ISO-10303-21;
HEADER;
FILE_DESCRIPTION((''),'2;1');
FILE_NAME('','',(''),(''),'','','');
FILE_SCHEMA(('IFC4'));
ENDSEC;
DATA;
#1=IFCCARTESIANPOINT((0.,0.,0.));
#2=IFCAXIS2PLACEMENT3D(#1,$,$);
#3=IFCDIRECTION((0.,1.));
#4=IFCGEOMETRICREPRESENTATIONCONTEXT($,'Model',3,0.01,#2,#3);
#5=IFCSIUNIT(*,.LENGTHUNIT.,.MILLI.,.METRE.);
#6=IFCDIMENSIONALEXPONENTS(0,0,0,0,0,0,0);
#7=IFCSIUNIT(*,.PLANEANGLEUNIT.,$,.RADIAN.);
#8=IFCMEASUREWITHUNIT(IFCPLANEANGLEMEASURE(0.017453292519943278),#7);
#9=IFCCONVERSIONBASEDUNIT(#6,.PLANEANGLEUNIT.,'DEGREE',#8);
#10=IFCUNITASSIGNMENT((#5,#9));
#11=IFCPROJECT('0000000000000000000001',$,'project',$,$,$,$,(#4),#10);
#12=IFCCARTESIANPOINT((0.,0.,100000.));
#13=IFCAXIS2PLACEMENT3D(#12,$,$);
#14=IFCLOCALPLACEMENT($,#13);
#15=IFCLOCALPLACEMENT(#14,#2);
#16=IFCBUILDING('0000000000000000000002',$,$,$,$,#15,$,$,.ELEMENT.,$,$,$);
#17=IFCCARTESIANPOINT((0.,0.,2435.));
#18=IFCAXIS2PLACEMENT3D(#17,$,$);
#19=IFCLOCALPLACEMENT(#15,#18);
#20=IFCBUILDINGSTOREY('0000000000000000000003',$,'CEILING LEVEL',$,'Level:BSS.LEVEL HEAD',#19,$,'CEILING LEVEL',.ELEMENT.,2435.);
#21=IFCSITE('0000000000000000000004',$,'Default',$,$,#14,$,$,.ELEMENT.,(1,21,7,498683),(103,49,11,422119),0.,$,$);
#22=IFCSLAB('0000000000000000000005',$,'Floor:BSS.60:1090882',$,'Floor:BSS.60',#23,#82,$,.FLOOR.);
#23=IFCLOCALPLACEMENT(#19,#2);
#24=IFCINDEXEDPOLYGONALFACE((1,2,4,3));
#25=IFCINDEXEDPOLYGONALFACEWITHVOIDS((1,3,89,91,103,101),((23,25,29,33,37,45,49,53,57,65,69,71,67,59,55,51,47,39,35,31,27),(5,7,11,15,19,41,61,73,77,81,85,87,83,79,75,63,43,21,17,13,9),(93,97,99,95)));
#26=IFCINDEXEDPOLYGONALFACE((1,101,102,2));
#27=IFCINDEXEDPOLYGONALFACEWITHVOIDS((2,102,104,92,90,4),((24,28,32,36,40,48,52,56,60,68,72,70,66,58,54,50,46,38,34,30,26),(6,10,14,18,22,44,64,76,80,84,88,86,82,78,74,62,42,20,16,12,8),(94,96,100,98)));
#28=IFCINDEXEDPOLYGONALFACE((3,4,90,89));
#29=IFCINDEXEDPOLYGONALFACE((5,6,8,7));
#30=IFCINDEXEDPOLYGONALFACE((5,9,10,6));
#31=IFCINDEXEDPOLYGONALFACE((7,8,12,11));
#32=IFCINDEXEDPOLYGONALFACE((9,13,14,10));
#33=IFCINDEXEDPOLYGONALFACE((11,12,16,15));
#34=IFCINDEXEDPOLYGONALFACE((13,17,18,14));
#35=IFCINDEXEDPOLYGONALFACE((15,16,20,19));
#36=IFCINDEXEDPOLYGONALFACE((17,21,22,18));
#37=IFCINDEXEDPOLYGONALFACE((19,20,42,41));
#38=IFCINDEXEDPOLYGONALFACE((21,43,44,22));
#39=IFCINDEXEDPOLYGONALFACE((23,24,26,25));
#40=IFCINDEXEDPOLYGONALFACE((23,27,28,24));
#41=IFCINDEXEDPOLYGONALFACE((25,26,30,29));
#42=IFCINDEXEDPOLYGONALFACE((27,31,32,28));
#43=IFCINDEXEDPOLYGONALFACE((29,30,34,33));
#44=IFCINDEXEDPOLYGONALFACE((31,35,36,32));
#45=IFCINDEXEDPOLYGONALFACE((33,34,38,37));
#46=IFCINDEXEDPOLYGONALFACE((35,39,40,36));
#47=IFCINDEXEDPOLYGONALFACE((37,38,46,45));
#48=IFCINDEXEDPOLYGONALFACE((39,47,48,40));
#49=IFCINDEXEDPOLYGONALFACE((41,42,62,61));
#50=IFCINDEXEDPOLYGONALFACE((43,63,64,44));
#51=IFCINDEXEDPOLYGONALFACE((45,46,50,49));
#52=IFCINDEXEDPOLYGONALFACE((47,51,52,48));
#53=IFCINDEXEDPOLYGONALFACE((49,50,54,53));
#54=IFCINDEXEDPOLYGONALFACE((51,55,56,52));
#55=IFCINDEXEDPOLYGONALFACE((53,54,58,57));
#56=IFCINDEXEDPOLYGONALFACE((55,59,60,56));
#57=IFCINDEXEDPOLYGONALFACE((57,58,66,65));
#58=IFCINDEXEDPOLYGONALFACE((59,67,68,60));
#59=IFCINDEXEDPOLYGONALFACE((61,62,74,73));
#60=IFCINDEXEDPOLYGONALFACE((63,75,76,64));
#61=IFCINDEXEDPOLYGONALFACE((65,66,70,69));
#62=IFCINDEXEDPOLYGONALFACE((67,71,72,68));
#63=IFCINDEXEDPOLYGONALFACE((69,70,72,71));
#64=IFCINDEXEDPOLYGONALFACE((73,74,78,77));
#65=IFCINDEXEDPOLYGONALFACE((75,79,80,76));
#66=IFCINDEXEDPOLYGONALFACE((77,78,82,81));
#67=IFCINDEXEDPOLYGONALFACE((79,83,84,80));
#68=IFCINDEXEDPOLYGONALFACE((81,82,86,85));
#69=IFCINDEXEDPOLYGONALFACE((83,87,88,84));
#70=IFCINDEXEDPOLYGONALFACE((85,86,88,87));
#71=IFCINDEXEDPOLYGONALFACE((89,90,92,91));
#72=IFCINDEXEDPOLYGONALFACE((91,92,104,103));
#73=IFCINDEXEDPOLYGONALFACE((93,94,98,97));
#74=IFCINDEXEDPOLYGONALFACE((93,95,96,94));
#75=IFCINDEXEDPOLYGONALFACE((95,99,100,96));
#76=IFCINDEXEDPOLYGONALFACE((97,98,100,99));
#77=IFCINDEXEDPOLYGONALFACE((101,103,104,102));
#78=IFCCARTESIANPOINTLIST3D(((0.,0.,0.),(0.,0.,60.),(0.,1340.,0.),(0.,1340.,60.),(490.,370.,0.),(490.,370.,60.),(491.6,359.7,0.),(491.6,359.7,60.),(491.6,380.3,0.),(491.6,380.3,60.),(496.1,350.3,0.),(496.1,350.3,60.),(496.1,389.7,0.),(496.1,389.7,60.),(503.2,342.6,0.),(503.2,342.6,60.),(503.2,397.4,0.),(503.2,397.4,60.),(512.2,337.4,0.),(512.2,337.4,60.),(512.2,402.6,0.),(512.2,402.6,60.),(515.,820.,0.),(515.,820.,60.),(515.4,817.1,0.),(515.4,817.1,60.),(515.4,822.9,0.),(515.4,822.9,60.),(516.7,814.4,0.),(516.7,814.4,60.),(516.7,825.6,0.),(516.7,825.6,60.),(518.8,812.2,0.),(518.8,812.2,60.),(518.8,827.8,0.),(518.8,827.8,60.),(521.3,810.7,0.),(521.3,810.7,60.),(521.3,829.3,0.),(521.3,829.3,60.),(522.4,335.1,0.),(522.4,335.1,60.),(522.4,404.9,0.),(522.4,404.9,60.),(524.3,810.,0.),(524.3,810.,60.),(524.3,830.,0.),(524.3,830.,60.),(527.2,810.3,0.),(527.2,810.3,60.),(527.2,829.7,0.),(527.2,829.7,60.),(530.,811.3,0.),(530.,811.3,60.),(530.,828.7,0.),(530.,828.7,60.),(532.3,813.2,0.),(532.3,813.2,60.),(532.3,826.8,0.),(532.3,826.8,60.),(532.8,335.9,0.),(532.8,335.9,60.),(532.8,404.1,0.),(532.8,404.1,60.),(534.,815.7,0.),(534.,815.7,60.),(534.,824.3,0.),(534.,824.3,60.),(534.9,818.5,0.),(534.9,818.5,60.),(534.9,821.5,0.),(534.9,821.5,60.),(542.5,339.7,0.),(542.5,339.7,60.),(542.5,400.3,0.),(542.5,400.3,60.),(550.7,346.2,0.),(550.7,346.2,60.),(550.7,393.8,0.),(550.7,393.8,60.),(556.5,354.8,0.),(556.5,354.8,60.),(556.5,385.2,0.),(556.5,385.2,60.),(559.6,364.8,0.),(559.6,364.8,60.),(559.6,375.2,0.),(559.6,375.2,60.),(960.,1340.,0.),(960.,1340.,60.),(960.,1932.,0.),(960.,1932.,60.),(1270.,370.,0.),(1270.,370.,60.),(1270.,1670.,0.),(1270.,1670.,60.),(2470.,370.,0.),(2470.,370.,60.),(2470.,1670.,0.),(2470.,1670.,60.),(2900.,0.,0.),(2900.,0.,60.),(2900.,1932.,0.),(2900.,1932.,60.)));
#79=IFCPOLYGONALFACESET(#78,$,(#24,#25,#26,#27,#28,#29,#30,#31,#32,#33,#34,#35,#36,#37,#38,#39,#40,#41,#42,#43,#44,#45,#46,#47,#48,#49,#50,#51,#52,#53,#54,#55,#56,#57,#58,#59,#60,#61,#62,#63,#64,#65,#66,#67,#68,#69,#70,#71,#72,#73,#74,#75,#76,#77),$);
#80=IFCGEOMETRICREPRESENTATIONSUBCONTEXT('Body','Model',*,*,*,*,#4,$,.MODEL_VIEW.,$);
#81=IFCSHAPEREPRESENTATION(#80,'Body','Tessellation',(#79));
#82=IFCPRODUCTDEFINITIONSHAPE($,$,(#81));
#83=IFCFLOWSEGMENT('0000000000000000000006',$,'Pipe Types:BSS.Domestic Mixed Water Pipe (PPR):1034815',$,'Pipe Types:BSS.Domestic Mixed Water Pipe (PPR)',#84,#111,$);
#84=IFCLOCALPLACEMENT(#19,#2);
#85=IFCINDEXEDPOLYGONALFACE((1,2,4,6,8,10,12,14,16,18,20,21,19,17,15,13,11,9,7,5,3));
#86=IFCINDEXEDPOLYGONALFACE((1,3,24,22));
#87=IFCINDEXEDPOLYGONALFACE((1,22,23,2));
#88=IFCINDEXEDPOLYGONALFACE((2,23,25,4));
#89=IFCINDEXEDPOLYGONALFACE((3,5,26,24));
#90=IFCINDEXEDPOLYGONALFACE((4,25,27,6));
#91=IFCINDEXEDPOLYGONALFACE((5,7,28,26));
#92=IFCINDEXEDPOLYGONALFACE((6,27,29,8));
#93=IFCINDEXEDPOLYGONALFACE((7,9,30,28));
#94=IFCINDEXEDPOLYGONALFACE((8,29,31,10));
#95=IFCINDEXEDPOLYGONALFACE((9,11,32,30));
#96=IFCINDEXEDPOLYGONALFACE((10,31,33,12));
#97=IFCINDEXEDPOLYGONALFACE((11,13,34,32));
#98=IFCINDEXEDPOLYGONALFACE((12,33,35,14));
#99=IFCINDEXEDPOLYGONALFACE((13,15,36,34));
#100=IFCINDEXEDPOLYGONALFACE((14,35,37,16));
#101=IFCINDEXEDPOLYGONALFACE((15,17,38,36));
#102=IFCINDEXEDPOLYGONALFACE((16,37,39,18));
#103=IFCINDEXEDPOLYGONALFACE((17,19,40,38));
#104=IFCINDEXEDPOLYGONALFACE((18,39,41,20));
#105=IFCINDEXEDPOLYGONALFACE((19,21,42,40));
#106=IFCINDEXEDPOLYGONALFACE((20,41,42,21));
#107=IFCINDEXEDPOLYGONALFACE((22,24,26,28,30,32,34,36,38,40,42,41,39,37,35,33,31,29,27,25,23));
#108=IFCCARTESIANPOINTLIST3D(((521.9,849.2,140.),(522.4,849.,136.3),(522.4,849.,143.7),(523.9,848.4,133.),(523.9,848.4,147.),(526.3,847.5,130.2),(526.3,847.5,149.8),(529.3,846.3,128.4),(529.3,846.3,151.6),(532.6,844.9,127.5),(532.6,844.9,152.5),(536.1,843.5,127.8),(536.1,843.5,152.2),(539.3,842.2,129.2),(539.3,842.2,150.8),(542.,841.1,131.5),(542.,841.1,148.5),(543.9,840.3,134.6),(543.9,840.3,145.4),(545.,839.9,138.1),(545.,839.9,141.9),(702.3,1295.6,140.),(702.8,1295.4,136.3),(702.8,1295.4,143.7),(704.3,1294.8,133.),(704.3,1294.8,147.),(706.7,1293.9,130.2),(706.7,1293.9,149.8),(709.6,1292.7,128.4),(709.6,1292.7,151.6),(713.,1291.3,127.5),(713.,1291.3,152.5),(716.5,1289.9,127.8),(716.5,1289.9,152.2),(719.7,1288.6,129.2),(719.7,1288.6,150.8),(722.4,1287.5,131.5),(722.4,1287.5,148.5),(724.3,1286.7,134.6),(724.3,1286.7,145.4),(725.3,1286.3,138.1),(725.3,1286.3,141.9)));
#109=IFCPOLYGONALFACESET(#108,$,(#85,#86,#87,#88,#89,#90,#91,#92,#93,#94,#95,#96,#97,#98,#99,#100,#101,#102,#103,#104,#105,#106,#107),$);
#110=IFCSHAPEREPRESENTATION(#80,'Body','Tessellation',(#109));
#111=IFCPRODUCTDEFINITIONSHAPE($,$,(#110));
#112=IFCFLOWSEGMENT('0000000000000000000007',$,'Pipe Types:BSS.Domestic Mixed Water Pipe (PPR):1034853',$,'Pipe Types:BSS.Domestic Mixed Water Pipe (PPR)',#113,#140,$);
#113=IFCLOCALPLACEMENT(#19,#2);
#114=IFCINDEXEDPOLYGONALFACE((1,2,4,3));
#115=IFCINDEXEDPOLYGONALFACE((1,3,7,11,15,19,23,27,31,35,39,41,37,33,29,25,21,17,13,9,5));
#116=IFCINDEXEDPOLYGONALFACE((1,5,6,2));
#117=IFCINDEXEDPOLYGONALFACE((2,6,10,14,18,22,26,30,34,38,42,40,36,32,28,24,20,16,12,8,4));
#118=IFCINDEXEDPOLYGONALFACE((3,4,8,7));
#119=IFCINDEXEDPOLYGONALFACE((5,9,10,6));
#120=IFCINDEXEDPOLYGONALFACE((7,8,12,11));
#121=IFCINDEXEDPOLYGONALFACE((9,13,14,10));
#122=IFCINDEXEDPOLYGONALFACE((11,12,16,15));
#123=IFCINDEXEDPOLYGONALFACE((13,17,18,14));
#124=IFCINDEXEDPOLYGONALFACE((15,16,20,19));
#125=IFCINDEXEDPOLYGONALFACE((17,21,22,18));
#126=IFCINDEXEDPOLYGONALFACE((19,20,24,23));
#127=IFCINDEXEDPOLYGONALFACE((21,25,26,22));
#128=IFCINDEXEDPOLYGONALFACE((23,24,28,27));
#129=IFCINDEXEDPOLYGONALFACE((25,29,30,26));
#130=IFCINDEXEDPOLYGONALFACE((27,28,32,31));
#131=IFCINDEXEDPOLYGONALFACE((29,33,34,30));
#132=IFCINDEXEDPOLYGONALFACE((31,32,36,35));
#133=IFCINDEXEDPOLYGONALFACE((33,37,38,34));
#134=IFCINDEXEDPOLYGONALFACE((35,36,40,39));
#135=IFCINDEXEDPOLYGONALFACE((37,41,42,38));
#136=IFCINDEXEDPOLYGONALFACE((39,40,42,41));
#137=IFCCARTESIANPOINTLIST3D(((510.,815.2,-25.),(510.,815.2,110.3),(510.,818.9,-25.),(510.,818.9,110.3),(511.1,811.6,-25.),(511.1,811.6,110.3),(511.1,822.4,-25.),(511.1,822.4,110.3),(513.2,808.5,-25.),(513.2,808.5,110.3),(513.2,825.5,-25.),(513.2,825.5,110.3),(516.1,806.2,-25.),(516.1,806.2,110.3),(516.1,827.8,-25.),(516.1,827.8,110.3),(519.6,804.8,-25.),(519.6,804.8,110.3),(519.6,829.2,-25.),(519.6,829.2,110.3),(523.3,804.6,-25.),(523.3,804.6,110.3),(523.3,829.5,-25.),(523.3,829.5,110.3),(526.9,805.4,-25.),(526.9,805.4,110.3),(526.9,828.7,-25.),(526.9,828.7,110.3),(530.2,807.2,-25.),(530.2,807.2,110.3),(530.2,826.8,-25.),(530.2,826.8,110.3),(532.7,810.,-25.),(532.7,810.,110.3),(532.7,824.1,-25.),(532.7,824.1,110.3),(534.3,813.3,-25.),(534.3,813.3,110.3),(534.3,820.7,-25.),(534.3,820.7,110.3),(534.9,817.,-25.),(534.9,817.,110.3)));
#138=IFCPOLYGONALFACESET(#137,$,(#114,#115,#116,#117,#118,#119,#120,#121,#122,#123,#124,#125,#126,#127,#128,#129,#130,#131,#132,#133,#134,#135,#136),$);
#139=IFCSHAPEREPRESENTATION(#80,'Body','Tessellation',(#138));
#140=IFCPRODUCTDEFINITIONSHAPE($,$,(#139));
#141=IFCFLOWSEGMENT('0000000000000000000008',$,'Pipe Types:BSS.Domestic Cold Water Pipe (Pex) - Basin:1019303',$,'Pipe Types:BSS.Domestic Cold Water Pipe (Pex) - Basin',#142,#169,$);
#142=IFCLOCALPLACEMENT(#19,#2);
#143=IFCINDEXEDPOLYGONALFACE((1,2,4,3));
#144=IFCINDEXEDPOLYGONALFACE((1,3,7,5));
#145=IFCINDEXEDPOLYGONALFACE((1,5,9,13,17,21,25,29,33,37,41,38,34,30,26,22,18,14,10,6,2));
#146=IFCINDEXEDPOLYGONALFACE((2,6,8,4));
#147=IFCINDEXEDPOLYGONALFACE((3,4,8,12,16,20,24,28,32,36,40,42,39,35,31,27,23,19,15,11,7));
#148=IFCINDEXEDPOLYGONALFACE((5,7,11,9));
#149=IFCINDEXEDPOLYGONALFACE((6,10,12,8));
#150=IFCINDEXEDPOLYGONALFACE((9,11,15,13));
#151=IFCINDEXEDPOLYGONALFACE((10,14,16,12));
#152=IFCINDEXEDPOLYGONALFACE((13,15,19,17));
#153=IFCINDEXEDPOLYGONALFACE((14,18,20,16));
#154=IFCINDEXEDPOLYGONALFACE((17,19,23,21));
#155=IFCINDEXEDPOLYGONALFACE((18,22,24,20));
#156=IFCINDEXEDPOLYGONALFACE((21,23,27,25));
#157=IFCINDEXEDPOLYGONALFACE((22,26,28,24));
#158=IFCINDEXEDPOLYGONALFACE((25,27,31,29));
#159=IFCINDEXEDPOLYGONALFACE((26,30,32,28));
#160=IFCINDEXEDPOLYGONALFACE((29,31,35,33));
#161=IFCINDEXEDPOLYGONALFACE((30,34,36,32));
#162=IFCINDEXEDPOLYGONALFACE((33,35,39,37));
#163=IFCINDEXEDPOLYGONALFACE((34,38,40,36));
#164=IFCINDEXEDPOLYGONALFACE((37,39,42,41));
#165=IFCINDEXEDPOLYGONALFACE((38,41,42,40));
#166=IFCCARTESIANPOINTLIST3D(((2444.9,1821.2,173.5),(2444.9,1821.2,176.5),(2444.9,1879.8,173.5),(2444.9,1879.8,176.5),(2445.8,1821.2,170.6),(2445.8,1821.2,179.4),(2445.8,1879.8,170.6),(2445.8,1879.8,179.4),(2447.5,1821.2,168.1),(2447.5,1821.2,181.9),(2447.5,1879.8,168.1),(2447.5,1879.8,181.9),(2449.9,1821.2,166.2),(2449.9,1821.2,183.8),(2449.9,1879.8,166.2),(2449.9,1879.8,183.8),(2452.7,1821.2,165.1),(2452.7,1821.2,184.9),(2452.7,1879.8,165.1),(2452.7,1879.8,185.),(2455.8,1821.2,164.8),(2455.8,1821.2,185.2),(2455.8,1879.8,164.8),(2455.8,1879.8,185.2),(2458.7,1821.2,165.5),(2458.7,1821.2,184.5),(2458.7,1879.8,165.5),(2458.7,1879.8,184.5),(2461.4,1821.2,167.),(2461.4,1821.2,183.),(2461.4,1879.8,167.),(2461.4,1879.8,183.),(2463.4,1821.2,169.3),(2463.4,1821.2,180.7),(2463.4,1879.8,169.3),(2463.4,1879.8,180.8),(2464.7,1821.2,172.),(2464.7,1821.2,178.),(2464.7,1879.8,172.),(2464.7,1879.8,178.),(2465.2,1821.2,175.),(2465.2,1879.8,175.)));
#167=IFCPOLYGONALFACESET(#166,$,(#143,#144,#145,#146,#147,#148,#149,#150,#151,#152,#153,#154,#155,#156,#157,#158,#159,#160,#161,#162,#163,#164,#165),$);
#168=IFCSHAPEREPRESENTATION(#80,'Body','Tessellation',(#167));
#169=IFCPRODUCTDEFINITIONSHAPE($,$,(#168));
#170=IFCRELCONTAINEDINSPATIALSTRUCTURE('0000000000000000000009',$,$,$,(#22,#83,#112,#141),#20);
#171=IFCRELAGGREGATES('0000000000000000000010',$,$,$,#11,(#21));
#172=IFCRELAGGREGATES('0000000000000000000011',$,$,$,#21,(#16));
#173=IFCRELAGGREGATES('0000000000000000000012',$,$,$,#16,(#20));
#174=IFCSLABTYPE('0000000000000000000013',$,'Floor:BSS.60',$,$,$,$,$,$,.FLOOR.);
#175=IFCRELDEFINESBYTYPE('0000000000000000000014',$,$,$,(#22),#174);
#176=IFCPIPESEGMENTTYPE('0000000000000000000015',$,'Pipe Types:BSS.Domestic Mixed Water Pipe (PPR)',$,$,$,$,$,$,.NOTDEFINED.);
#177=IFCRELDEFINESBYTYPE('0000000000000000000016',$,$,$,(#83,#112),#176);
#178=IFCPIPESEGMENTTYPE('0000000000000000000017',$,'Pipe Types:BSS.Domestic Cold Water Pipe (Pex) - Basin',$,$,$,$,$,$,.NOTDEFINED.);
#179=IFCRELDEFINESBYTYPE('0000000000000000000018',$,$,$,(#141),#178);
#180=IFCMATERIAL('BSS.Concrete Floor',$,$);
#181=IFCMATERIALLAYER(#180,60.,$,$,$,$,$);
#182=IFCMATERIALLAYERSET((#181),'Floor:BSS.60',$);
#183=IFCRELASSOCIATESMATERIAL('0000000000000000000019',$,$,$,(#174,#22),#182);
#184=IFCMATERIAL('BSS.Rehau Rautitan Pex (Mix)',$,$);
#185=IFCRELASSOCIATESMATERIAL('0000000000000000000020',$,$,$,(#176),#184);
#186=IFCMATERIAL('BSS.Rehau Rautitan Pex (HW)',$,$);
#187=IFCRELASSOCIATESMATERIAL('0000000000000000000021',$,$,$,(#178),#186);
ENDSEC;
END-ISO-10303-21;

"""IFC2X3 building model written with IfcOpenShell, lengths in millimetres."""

from ifc_helpers import new_model, entity, si_unit, converted_unit, direction, frame, frame_2d, origin, origin_2d_with_axis, place, context, subcontext, project, spatial, polyline, rectangle, circle, outline, extrude, material, layer, layer_set, layer_usage, type_object, element, save


model = new_model("IFC2X3")

# Units and contexts
model_context = context("Model", 3, precision=0.01, world=origin(), true_north=direction((0.0, 1.0)))
body_context = subcontext(model_context, "Body", "Model", "MODEL_VIEW")
ifc_project = project(units=[si_unit("LENGTHUNIT", "METRE", prefix="MILLI"), converted_unit("PLANEANGLEUNIT", "DEGREE", entity("IfcPlaneAngleMeasure", 0.017453292519943278), si_unit("PLANEANGLEUNIT", "RADIAN"), dimensions=[0, 0, 0, 0, 0, 0, 0])], contexts=[model_context])

# Site, building, storey
site_placement = place(None, frame((0.0, 0.0, 100000.0)))
site = spatial("IfcSite", under=ifc_project, at=site_placement, Name="Default", CompositionType="ELEMENT", RefLatitude=(1, 21, 7, 498683), RefLongitude=(103, 49, 11, 422119), RefElevation=0.0)
building_placement = place(site_placement, origin())
building = spatial("IfcBuilding", under=site, at=building_placement, CompositionType="ELEMENT")
storey_placement = place(building_placement, frame((0.0, 0.0, 2435.0)))
storey = spatial("IfcBuildingStorey", under=building, at=storey_placement, Name="CEILING LEVEL", ObjectType="Level:BSS.LEVEL HEAD", LongName="CEILING LEVEL", CompositionType="ELEMENT", Elevation=2435.0)

# Slab, openings
ifc_material_1 = material(Name="BSS.Concrete Floor")
ifc_layer = layer(ifc_material_1, 60.0)
ifc_layer_set = layer_set([ifc_layer], Name="Floor:BSS.60")
ifc_layer_usage = layer_usage(ifc_layer_set, "AXIS3", "POSITIVE", 0.0)
slab_type = type_object("IfcSlabType", Name="Floor:BSS.60", PredefinedType="FLOOR", material=ifc_layer_set)
slab_placement = place(storey_placement, origin())
slab = element("IfcSlab", 1, at=slab_placement, inside=storey, type_object=slab_type, material=ifc_layer_usage, Name="Floor:BSS.60:1090882", ObjectType="Floor:BSS.60", PredefinedType="FLOOR", context=body_context, shape_type="SweptSolid", body=[
    extrude(outline(polyline([(-1450.0, -966.0), (1450.0, -966.0), (1450.0, 374.0), (490.0, 374.0), (490.0, 966.0), (-1450.0, 966.0), (-1450.0, -966.0)])), frame((1450.0, 966.0, 60.0), z_axis=(0.0, 0.0, -1.0), x_axis=(-1.0, 0.0, 0.0)), (0.0, 0.0, 1.0), 60.0),
])
opening_1_placement = place(slab_placement, origin())
element("IfcOpeningElement", 2, at=opening_1_placement, cuts=slab, ObjectType="Opening", context=body_context, shape_type="SweptSolid", body=[
    extrude(rectangle(XDim=1200.0, YDim=1300.0, at=frame_2d((0.0, 0.0), x_axis=(1.0, 0.0))), frame((1870.0, 1020.0, 60.0), z_axis=(0.0, 0.0, -1.0), x_axis=(1.0, 0.0, 0.0)), (0.0, 0.0, 1.0), 60.0),
])
opening_2_placement = place(slab_placement, origin())
element("IfcOpeningElement", 3, at=opening_2_placement, cuts=slab, ObjectType="Opening", context=body_context, shape_type="SweptSolid", body=[
    extrude(circle(Radius=10.0, at=origin_2d_with_axis()), frame((525.0, 820.0, 60.0), z_axis=(0.0, 0.0, -1.0), x_axis=(-1.0, 0.0, 0.0)), (0.0, 0.0, 1.0), 60.0),
])
opening_3_placement = place(slab_placement, origin())
element("IfcOpeningElement", 4, at=opening_3_placement, cuts=slab, ObjectType="Opening", context=body_context, shape_type="SweptSolid", body=[
    extrude(circle(Radius=35.0, at=frame_2d((0.0, 0.0), x_axis=(1.0, 0.0))), frame((525.0, 370.0, 60.0), z_axis=(0.0, 0.0, -1.0), x_axis=(-1.0, 0.0, 0.0)), (0.0, 0.0, 1.0), 60.0),
])

# Flow segments
ifc_material_2 = material(Name="BSS.Rehau Rautitan Pex (Mix)")
pipe_segment_type_1 = type_object("IfcPipeSegmentType", Name="Pipe Types:BSS.Domestic Mixed Water Pipe (PPR)", PredefinedType="NOTDEFINED", material=ifc_material_2)
flow_segment_1_placement = place(storey_placement, origin())
element("IfcFlowSegment", 5, at=flow_segment_1_placement, inside=storey, type_object=pipe_segment_type_1, Name="Pipe Types:BSS.Domestic Mixed Water Pipe (PPR):1034815", ObjectType="Pipe Types:BSS.Domestic Mixed Water Pipe (PPR)", context=body_context, shape_type="SweptSolid", body=[
    extrude(circle(Radius=12.5, at=frame_2d((0.0, 0.0), x_axis=(1.0, 0.0))), frame((533.5, 844.5, 140.0), z_axis=(0.374644, 0.927169, 0.0), x_axis=(-0.927169, 0.374644, 0.000002)), (0.0, 0.0, 1.0), 481.5),
])
flow_segment_2_placement = place(storey_placement, origin())
element("IfcFlowSegment", 6, at=flow_segment_2_placement, inside=storey, type_object=pipe_segment_type_1, Name="Pipe Types:BSS.Domestic Mixed Water Pipe (PPR):1034853", ObjectType="Pipe Types:BSS.Domestic Mixed Water Pipe (PPR)", context=body_context, shape_type="SweptSolid", body=[
    extrude(circle(Radius=12.5, at=frame_2d((0.0, 0.0), x_axis=(1.0, 0.0))), frame((522.4, 817.0, -25.0)), (0.0, 0.0, 1.0), 135.3),
])
ifc_material_3 = material(Name="BSS.Rehau Rautitan Pex (HW)")
pipe_segment_type_2 = type_object("IfcPipeSegmentType", Name="Pipe Types:BSS.Domestic Cold Water Pipe (Pex) - Basin", PredefinedType="NOTDEFINED", material=ifc_material_3)
flow_segment_3_placement = place(storey_placement, origin())
element("IfcFlowSegment", 7, at=flow_segment_3_placement, inside=storey, type_object=pipe_segment_type_2, Name="Pipe Types:BSS.Domestic Cold Water Pipe (Pex) - Basin:1019303", ObjectType="Pipe Types:BSS.Domestic Cold Water Pipe (Pex) - Basin", context=body_context, shape_type="SweptSolid", body=[
    extrude(circle(Radius=10.2, at=origin_2d_with_axis()), frame((2455.0, 1821.2, 175.0), z_axis=(0.000003, 1.0, 0.000117), x_axis=(1.0, -0.000003, 0.0)), (0.0, 0.0, 1.0), 58.6),
])

save(model, "model.ifc")
